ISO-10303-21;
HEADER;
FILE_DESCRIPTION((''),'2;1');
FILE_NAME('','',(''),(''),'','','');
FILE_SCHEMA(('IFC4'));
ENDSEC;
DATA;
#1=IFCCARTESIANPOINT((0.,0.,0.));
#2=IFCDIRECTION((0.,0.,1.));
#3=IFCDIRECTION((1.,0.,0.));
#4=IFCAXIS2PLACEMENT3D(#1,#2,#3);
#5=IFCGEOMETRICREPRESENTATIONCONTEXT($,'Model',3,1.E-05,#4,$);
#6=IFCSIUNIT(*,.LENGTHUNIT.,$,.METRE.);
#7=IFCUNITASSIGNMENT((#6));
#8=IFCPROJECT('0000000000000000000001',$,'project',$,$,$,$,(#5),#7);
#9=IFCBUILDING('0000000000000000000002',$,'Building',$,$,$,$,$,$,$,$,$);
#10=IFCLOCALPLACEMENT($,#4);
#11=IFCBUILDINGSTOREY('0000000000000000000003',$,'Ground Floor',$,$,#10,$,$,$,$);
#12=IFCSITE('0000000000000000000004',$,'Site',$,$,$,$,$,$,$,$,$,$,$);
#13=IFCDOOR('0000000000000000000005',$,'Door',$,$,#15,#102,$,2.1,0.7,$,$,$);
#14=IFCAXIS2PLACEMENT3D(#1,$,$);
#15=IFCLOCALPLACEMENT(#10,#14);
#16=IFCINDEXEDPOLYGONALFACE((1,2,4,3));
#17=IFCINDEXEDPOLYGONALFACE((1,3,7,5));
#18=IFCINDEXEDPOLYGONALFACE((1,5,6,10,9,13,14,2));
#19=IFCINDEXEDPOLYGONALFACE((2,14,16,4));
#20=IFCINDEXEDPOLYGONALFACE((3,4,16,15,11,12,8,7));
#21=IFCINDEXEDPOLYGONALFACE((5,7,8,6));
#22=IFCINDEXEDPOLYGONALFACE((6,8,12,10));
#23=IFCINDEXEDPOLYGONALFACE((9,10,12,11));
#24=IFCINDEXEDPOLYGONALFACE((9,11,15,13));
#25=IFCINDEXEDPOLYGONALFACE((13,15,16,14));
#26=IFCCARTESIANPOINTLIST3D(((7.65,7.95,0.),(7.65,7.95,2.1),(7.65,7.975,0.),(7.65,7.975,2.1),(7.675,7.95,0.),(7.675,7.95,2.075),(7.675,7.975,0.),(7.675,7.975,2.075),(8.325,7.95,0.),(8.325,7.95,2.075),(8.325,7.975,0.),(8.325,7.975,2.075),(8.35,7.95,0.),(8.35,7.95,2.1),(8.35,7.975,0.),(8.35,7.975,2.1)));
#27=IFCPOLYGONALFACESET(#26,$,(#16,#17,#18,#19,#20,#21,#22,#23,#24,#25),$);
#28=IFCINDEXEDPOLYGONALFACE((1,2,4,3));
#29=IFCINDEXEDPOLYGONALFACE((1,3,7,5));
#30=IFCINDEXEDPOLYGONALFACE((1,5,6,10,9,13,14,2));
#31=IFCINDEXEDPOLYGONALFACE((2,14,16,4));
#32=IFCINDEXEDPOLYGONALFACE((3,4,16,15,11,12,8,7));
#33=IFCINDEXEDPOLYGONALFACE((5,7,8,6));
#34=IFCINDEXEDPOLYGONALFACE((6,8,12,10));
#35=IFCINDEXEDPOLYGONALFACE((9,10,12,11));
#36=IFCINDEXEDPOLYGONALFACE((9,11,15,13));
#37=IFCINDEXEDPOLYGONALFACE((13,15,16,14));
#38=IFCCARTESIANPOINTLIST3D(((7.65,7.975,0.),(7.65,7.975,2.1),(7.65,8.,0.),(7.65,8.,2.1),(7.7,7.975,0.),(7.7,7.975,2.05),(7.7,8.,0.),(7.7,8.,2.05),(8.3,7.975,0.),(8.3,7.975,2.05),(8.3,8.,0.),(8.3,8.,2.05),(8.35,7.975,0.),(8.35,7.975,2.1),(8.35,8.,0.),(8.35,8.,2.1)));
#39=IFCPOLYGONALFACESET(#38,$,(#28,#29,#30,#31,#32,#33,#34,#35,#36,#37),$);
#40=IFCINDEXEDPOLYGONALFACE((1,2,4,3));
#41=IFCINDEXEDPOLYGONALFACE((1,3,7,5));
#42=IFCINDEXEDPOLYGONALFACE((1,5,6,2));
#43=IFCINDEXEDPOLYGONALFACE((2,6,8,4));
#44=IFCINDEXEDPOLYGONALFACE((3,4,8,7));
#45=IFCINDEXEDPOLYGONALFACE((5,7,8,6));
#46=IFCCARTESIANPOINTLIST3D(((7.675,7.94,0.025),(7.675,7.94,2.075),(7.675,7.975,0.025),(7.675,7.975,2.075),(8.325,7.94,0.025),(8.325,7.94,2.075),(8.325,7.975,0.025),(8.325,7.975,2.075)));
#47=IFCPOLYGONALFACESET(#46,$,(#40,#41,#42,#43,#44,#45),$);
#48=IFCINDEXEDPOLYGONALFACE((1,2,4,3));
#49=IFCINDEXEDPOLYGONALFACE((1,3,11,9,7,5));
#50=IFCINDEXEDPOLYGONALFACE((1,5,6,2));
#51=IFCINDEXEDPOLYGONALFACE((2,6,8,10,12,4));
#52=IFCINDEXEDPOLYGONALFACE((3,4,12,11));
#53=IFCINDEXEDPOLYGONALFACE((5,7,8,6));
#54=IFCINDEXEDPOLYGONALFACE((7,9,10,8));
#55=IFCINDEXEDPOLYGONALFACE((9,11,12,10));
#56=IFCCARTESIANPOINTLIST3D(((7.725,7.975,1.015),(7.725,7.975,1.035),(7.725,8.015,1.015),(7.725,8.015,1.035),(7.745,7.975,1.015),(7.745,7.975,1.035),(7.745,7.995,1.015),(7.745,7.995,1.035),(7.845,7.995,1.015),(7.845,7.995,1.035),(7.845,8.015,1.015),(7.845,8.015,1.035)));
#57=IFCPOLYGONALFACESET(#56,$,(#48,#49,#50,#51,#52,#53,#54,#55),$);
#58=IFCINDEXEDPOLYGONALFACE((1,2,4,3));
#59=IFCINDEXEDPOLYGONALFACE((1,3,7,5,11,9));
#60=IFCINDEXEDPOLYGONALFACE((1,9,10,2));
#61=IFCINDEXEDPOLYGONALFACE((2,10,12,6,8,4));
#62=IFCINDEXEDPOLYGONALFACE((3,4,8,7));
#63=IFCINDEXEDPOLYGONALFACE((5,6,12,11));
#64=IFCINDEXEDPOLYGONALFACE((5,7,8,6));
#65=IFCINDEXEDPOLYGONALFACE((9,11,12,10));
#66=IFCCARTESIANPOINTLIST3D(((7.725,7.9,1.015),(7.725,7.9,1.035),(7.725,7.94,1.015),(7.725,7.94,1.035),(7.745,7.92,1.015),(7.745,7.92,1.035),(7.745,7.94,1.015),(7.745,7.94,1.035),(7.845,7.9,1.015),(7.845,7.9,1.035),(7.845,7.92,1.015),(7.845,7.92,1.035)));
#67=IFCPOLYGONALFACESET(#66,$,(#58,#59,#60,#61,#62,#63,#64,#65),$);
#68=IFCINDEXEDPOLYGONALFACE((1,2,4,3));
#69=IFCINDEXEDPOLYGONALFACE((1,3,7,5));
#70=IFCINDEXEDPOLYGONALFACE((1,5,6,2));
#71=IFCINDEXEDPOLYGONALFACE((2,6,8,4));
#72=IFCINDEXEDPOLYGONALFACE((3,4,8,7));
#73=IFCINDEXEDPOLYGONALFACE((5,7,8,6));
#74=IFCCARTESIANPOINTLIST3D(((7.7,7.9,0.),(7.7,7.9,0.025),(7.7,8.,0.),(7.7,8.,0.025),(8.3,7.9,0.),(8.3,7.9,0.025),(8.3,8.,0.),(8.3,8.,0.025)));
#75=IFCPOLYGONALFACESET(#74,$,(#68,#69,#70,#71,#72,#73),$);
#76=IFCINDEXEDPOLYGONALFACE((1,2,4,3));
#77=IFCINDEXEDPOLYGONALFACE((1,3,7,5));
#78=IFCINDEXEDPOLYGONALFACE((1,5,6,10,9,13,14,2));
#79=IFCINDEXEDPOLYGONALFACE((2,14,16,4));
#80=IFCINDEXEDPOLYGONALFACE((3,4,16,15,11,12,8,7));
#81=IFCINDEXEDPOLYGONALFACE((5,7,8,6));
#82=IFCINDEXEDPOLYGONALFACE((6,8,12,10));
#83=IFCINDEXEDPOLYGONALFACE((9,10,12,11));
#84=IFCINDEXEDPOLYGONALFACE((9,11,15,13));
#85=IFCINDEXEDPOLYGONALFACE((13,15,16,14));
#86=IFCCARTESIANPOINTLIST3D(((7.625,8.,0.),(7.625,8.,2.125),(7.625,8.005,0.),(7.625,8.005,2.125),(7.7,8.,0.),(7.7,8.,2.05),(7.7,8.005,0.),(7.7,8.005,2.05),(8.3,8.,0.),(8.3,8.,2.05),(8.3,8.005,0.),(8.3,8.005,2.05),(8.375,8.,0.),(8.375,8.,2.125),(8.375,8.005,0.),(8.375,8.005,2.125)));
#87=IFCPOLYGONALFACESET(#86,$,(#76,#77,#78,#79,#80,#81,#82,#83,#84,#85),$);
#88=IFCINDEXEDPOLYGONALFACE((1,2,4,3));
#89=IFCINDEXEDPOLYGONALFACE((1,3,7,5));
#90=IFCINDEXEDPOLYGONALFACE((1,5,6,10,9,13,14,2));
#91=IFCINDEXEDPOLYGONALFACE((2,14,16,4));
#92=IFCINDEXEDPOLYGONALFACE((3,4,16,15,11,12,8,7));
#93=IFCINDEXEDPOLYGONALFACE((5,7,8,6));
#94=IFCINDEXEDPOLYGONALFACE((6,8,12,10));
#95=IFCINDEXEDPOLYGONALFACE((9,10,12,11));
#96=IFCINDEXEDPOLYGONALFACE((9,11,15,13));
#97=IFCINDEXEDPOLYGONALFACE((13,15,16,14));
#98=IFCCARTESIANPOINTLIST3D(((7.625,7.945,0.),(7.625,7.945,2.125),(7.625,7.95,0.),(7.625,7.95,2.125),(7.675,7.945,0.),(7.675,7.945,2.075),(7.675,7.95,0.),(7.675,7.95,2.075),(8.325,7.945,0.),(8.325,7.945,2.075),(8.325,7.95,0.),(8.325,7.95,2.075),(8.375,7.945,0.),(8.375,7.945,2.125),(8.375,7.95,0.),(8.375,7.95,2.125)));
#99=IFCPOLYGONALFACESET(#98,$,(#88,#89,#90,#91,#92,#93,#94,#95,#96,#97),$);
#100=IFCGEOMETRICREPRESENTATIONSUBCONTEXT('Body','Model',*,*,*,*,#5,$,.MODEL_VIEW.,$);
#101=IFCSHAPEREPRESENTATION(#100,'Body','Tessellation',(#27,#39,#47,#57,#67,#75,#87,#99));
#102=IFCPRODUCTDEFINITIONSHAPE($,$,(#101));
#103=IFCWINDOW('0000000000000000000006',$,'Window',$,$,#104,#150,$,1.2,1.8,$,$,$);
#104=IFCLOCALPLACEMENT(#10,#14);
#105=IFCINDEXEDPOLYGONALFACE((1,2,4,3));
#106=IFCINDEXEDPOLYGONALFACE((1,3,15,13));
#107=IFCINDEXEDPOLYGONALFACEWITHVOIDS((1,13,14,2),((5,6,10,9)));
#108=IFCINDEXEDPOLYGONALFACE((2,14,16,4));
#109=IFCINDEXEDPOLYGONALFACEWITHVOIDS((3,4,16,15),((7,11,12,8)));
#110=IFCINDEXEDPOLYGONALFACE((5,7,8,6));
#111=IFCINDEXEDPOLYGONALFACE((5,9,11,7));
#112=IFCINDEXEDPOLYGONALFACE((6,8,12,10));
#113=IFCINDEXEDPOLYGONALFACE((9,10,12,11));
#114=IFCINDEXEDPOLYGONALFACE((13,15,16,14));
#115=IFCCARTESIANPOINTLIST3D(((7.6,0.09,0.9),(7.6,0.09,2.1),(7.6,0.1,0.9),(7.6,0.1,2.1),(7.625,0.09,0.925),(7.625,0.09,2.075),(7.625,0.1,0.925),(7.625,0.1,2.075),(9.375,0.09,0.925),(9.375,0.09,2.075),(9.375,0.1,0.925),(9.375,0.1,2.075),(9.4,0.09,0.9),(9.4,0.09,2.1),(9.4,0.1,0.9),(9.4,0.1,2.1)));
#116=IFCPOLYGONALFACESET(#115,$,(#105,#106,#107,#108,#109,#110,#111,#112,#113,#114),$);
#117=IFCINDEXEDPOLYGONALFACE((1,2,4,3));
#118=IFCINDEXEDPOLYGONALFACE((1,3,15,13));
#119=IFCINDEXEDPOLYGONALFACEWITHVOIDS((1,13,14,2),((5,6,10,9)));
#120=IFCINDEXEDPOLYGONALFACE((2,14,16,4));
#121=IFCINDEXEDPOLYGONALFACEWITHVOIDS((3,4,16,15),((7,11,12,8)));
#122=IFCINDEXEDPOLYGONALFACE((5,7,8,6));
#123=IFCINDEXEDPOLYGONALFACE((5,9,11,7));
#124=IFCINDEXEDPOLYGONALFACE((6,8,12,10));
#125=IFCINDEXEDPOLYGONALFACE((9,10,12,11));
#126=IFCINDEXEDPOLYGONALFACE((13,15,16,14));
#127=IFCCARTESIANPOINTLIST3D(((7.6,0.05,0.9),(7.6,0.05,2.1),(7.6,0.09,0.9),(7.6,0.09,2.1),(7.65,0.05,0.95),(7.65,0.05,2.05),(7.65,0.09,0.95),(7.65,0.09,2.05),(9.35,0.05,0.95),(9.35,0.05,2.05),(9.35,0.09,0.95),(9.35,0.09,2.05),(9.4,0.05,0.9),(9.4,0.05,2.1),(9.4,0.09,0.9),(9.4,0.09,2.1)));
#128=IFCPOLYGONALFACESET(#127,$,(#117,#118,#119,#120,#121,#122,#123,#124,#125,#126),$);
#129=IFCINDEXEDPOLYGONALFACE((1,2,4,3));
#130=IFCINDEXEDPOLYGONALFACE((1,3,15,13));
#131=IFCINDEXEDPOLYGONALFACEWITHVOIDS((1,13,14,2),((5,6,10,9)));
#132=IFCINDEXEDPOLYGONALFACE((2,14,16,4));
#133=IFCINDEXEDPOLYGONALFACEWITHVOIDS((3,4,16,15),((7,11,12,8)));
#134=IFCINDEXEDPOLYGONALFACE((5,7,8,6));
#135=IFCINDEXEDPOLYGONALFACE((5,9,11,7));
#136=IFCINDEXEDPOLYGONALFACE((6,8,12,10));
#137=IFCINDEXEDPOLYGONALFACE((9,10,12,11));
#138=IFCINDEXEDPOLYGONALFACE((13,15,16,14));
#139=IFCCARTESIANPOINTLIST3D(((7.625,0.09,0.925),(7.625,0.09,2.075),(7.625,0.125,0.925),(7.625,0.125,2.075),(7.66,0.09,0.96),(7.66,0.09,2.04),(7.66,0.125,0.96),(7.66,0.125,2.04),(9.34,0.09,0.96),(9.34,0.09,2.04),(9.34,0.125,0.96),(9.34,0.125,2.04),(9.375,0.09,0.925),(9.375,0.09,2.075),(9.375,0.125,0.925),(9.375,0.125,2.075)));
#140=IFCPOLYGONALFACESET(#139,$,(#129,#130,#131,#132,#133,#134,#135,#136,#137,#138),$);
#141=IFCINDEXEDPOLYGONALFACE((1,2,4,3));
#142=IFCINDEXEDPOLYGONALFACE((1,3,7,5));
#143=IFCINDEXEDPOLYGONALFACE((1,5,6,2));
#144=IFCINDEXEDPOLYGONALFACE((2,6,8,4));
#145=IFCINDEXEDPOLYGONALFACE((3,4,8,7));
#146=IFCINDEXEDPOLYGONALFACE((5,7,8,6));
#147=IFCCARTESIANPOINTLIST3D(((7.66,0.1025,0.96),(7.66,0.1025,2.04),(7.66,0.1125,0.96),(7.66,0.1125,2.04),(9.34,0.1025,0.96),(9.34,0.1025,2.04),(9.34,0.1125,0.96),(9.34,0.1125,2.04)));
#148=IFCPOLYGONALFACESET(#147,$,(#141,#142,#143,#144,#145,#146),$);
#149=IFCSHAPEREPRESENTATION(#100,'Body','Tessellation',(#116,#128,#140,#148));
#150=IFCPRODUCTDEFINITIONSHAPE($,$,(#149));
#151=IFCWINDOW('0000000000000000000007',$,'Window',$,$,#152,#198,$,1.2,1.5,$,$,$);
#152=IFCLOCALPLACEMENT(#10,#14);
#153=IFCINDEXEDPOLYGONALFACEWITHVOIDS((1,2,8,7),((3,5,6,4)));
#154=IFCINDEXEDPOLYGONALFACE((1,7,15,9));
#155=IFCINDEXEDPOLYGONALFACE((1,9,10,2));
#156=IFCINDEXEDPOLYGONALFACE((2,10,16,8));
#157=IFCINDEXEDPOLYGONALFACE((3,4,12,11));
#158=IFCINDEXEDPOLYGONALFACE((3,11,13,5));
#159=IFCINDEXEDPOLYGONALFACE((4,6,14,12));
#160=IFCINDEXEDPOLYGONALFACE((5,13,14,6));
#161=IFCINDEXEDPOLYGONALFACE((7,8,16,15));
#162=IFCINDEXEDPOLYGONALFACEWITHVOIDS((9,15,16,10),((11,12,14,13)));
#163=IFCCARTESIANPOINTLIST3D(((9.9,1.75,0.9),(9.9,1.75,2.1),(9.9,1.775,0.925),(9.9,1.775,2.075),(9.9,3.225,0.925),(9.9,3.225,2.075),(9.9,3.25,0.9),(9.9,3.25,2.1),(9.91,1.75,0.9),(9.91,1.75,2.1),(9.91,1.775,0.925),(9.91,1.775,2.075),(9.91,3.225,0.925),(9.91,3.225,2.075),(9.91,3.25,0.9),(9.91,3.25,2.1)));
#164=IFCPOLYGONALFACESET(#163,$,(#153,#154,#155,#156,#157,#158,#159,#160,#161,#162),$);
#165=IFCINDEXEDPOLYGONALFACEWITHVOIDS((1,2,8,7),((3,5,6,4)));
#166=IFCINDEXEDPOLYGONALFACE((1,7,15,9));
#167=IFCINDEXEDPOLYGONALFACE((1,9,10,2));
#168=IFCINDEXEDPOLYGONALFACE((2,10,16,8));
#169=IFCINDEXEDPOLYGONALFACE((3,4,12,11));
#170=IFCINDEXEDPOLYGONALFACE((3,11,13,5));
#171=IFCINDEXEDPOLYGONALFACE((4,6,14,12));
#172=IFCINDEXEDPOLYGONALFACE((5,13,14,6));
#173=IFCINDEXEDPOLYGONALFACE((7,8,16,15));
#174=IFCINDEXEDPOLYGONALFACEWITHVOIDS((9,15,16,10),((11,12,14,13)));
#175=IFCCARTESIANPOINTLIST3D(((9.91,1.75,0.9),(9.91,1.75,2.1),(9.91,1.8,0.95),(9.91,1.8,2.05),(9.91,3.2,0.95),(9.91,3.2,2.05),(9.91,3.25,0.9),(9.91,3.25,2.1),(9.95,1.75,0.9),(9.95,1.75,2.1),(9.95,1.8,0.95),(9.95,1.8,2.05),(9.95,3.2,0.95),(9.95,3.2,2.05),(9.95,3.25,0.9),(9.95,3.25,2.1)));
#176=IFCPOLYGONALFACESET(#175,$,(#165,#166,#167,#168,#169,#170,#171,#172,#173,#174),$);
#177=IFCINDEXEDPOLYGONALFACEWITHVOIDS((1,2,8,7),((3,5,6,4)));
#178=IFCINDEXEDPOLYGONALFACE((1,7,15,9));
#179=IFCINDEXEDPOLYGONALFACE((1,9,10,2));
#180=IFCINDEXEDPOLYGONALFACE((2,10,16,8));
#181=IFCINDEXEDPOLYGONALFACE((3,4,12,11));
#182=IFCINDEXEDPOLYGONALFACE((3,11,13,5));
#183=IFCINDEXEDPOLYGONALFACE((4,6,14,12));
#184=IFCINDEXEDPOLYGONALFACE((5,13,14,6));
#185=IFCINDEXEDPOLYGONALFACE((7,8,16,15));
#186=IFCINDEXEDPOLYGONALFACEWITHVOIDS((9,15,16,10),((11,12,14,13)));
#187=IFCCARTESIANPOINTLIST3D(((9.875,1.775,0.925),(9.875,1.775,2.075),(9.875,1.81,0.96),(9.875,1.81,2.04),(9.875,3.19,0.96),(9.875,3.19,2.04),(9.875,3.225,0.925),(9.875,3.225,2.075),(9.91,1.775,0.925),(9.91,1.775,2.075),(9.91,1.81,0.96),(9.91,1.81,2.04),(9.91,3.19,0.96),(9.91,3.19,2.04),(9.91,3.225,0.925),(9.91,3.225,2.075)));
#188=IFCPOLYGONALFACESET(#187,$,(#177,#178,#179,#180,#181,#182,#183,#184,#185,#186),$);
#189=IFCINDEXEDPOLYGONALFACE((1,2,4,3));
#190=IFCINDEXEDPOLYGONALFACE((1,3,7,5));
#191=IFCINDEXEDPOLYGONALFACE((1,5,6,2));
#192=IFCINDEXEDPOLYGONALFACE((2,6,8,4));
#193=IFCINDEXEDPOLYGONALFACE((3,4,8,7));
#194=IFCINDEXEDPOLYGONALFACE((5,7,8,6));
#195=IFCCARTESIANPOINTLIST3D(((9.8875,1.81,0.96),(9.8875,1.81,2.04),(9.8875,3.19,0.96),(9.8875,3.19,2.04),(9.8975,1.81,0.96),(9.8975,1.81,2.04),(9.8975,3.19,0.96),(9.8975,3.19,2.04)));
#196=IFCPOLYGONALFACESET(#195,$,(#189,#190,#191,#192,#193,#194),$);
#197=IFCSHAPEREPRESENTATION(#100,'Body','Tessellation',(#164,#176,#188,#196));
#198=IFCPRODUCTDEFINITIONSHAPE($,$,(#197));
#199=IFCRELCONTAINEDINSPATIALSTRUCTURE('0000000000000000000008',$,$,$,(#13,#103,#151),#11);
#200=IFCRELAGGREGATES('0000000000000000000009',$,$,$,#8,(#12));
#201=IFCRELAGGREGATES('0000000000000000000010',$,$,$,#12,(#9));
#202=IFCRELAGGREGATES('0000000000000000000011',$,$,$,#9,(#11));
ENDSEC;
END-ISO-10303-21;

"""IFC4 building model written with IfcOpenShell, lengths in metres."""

from ifc_helpers import new_model, si_unit, frame, origin_with_axes, place, context, subcontext, project, spatial, line, indexed_curve, outline, extrude, element, save


model = new_model("IFC4")

# Units and contexts
model_context = context("Model", 3, precision=1e-05, world=origin_with_axes())
body_context = subcontext(model_context, "Body", "Model", "MODEL_VIEW")
ifc_project = project(units=[si_unit("LENGTHUNIT", "METRE")], contexts=[model_context])

# Site, building, storey
site = spatial("IfcSite", under=ifc_project, Name="Site")
building = spatial("IfcBuilding", under=site, Name="Building")
storey_placement = place(None, origin_with_axes())
storey = spatial("IfcBuildingStorey", under=building, at=storey_placement, Name="Ground Floor")

# Door
door_1_placement = place(storey_placement, frame((8.35, 8.0, 0.0), z_axis=(0.0, 0.0, 1.0), x_axis=(-1.0, 0.0, 0.0)))
element("IfcDoor", 1, at=door_1_placement, inside=storey, Name="Door", OverallHeight=2.1, OverallWidth=0.7, context=body_context, shape_type="SweptSolid", body=[
    extrude(outline(indexed_curve([(0.0, 0.0), (0.0, 2.1), (0.7, 2.1), (0.7, 0.0), (0.675, 0.0), (0.675, 2.075), (0.025, 2.075), (0.025, 0.0)], segments=[line(1, 2, 3, 4, 5, 6, 7, 8, 1)])), frame((0.0, 0.025, 0.0), z_axis=(0.0, -1.0, 0.0), x_axis=(1.0, 0.0, 0.0)), (0.0, 0.0, -1.0), 0.025),
    extrude(outline(indexed_curve([(0.0, 0.0), (0.0, 2.1), (0.7, 2.1), (0.7, 0.0), (0.65, 0.0), (0.65, 2.05), (0.05, 2.05), (0.05, 0.0)], segments=[line(1, 2, 3, 4, 5, 6, 7, 8, 1)])), frame((0.0, 0.0, 0.0), z_axis=(0.0, -1.0, 0.0), x_axis=(1.0, 0.0, 0.0)), (0.0, 0.0, -1.0), 0.025),
    extrude(outline(indexed_curve([(0.0, 0.0), (0.65, 0.0), (0.65, 0.035), (0.0, 0.035)], segments=[line(1, 2, 3, 4, 1)])), frame((0.025, 0.025, 0.025), z_axis=(0.0, 0.0, 1.0), x_axis=(1.0, 0.0, 0.0)), (0.0, 0.0, 1.0), 2.05),
    extrude(outline(indexed_curve([(0.0, 0.0), (0.0, -0.04), (-0.12, -0.04), (-0.12, -0.02), (-0.02, -0.02), (-0.02, 0.0)], segments=[line(1, 2, 3, 4, 5, 6, 1)])), frame((0.625, 0.025, 1.015), z_axis=(0.0, 0.0, 1.0), x_axis=(1.0, 0.0, 0.0)), (0.0, 0.0, 1.0), 0.02),
    extrude(outline(indexed_curve([(0.0, 0.0), (0.0, 0.04), (-0.12, 0.04), (-0.12, 0.02), (-0.02, 0.02), (-0.02, 0.0)], segments=[line(1, 2, 3, 4, 5, 6, 1)])), frame((0.625, 0.06, 1.015), z_axis=(0.0, 0.0, 1.0), x_axis=(1.0, 0.0, 0.0)), (0.0, 0.0, 1.0), 0.02),
    extrude(outline(indexed_curve([(0.0, 0.0), (0.6, 0.0), (0.6, 0.1), (0.0, 0.1)], segments=[line(1, 2, 3, 4, 1)])), frame((0.05, 0.0, 0.0), z_axis=(0.0, 0.0, 1.0), x_axis=(1.0, 0.0, 0.0)), (0.0, 0.0, 1.0), 0.025),
    extrude(outline(indexed_curve([(0.0, 0.0), (0.0, 2.125), (0.75, 2.125), (0.75, 0.0), (0.675, 0.0), (0.675, 2.05), (0.075, 2.05), (0.075, 0.0)], segments=[line(1, 2, 3, 4, 5, 6, 7, 8, 1)])), frame((-0.025, -0.005, 0.0), z_axis=(0.0, -1.0, 0.0), x_axis=(1.0, 0.0, 0.0)), (0.0, 0.0, -1.0), 0.005),
    extrude(outline(indexed_curve([(0.0, 0.0), (0.0, 2.125), (0.75, 2.125), (0.75, 0.0), (0.7, 0.0), (0.7, 2.075), (0.05, 2.075), (0.05, 0.0)], segments=[line(1, 2, 3, 4, 5, 6, 7, 8, 1)])), frame((-0.025, 0.05, 0.0), z_axis=(0.0, -1.0, 0.0), x_axis=(1.0, 0.0, 0.0)), (0.0, 0.0, -1.0), 0.005),
])

# Windows
window_1_placement = place(storey_placement, frame((7.6, 0.0, 0.9), z_axis=(0.0, 0.0, 1.0), x_axis=(1.0, 0.0, 0.0)))
element("IfcWindow", 2, at=window_1_placement, inside=storey, Name="Window", OverallHeight=1.2, OverallWidth=1.8, context=body_context, shape_type="SweptSolid", body=[
    extrude(outline(indexed_curve([(0.0, 0.0), (1.8, 0.0), (1.8, 1.2), (0.0, 1.2)], segments=[line(1, 2, 3, 4, 1)]), holes=[indexed_curve([(0.025, 0.025), (1.775, 0.025), (1.775, 1.175), (0.025, 1.175)], segments=[line(1, 2, 3, 4, 1)])]), frame((0.0, 0.09, 0.0), z_axis=(0.0, -1.0, 0.0), x_axis=(1.0, 0.0, 0.0)), (0.0, 0.0, -1.0), 0.01),
    extrude(outline(indexed_curve([(0.0, 0.0), (1.8, 0.0), (1.8, 1.2), (0.0, 1.2)], segments=[line(1, 2, 3, 4, 1)]), holes=[indexed_curve([(0.05, 0.05), (1.75, 0.05), (1.75, 1.15), (0.05, 1.15)], segments=[line(1, 2, 3, 4, 1)])]), frame((0.0, 0.05, 0.0), z_axis=(0.0, -1.0, 0.0), x_axis=(1.0, 0.0, 0.0)), (0.0, 0.0, -1.0), 0.04),
    extrude(outline(indexed_curve([(0.0, 0.0), (1.75, 0.0), (1.75, 1.15), (0.0, 1.15)], segments=[line(1, 2, 3, 4, 1)]), holes=[indexed_curve([(0.035, 0.035), (1.715, 0.035), (1.715, 1.115), (0.035, 1.115)], segments=[line(1, 2, 3, 4, 1)])]), frame((0.025, 0.09, 0.025), z_axis=(0.0, -1.0, 0.0), x_axis=(1.0, 0.0, 0.0)), (0.0, 0.0, -1.0), 0.035),
    extrude(outline(indexed_curve([(0.035, 0.035), (1.715, 0.035), (1.715, 1.115), (0.035, 1.115)], segments=[line(1, 2, 3, 4, 1)])), frame((0.025, 0.1025, 0.025), z_axis=(0.0, -1.0, 0.0), x_axis=(1.0, 0.0, 0.0)), (0.0, 0.0, -1.0), 0.01),
])
for number, where, z_axis, x_axis, name in (
    (3, (10.0, 1.75, 0.9), (0.0, 0.0, 1.0), (0.0, 1.0, 0.0), "Window"),
):
    element("IfcWindow", number, at=place(storey_placement, frame(where, z_axis=z_axis, x_axis=x_axis)), inside=storey, Name=name, OverallHeight=1.2, OverallWidth=1.5, context=body_context, shape_type="SweptSolid", body=[
        extrude(outline(indexed_curve([(0.0, 0.0), (1.5, 0.0), (1.5, 1.2), (0.0, 1.2)], segments=[line(1, 2, 3, 4, 1)]), holes=[indexed_curve([(0.025, 0.025), (1.475, 0.025), (1.475, 1.175), (0.025, 1.175)], segments=[line(1, 2, 3, 4, 1)])]), frame((0.0, 0.09, 0.0), z_axis=(0.0, -1.0, 0.0), x_axis=(1.0, 0.0, 0.0)), (0.0, 0.0, -1.0), 0.01),
        extrude(outline(indexed_curve([(0.0, 0.0), (1.5, 0.0), (1.5, 1.2), (0.0, 1.2)], segments=[line(1, 2, 3, 4, 1)]), holes=[indexed_curve([(0.05, 0.05), (1.45, 0.05), (1.45, 1.15), (0.05, 1.15)], segments=[line(1, 2, 3, 4, 1)])]), frame((0.0, 0.05, 0.0), z_axis=(0.0, -1.0, 0.0), x_axis=(1.0, 0.0, 0.0)), (0.0, 0.0, -1.0), 0.04),
        extrude(outline(indexed_curve([(0.0, 0.0), (1.45, 0.0), (1.45, 1.15), (0.0, 1.15)], segments=[line(1, 2, 3, 4, 1)]), holes=[indexed_curve([(0.035, 0.035), (1.415, 0.035), (1.415, 1.115), (0.035, 1.115)], segments=[line(1, 2, 3, 4, 1)])]), frame((0.025, 0.09, 0.025), z_axis=(0.0, -1.0, 0.0), x_axis=(1.0, 0.0, 0.0)), (0.0, 0.0, -1.0), 0.035),
        extrude(outline(indexed_curve([(0.035, 0.035), (1.415, 0.035), (1.415, 1.115), (0.035, 1.115)], segments=[line(1, 2, 3, 4, 1)])), frame((0.025, 0.1025, 0.025), z_axis=(0.0, -1.0, 0.0), x_axis=(1.0, 0.0, 0.0)), (0.0, 0.0, -1.0), 0.01),
    ])

save(model, "model.ifc")
